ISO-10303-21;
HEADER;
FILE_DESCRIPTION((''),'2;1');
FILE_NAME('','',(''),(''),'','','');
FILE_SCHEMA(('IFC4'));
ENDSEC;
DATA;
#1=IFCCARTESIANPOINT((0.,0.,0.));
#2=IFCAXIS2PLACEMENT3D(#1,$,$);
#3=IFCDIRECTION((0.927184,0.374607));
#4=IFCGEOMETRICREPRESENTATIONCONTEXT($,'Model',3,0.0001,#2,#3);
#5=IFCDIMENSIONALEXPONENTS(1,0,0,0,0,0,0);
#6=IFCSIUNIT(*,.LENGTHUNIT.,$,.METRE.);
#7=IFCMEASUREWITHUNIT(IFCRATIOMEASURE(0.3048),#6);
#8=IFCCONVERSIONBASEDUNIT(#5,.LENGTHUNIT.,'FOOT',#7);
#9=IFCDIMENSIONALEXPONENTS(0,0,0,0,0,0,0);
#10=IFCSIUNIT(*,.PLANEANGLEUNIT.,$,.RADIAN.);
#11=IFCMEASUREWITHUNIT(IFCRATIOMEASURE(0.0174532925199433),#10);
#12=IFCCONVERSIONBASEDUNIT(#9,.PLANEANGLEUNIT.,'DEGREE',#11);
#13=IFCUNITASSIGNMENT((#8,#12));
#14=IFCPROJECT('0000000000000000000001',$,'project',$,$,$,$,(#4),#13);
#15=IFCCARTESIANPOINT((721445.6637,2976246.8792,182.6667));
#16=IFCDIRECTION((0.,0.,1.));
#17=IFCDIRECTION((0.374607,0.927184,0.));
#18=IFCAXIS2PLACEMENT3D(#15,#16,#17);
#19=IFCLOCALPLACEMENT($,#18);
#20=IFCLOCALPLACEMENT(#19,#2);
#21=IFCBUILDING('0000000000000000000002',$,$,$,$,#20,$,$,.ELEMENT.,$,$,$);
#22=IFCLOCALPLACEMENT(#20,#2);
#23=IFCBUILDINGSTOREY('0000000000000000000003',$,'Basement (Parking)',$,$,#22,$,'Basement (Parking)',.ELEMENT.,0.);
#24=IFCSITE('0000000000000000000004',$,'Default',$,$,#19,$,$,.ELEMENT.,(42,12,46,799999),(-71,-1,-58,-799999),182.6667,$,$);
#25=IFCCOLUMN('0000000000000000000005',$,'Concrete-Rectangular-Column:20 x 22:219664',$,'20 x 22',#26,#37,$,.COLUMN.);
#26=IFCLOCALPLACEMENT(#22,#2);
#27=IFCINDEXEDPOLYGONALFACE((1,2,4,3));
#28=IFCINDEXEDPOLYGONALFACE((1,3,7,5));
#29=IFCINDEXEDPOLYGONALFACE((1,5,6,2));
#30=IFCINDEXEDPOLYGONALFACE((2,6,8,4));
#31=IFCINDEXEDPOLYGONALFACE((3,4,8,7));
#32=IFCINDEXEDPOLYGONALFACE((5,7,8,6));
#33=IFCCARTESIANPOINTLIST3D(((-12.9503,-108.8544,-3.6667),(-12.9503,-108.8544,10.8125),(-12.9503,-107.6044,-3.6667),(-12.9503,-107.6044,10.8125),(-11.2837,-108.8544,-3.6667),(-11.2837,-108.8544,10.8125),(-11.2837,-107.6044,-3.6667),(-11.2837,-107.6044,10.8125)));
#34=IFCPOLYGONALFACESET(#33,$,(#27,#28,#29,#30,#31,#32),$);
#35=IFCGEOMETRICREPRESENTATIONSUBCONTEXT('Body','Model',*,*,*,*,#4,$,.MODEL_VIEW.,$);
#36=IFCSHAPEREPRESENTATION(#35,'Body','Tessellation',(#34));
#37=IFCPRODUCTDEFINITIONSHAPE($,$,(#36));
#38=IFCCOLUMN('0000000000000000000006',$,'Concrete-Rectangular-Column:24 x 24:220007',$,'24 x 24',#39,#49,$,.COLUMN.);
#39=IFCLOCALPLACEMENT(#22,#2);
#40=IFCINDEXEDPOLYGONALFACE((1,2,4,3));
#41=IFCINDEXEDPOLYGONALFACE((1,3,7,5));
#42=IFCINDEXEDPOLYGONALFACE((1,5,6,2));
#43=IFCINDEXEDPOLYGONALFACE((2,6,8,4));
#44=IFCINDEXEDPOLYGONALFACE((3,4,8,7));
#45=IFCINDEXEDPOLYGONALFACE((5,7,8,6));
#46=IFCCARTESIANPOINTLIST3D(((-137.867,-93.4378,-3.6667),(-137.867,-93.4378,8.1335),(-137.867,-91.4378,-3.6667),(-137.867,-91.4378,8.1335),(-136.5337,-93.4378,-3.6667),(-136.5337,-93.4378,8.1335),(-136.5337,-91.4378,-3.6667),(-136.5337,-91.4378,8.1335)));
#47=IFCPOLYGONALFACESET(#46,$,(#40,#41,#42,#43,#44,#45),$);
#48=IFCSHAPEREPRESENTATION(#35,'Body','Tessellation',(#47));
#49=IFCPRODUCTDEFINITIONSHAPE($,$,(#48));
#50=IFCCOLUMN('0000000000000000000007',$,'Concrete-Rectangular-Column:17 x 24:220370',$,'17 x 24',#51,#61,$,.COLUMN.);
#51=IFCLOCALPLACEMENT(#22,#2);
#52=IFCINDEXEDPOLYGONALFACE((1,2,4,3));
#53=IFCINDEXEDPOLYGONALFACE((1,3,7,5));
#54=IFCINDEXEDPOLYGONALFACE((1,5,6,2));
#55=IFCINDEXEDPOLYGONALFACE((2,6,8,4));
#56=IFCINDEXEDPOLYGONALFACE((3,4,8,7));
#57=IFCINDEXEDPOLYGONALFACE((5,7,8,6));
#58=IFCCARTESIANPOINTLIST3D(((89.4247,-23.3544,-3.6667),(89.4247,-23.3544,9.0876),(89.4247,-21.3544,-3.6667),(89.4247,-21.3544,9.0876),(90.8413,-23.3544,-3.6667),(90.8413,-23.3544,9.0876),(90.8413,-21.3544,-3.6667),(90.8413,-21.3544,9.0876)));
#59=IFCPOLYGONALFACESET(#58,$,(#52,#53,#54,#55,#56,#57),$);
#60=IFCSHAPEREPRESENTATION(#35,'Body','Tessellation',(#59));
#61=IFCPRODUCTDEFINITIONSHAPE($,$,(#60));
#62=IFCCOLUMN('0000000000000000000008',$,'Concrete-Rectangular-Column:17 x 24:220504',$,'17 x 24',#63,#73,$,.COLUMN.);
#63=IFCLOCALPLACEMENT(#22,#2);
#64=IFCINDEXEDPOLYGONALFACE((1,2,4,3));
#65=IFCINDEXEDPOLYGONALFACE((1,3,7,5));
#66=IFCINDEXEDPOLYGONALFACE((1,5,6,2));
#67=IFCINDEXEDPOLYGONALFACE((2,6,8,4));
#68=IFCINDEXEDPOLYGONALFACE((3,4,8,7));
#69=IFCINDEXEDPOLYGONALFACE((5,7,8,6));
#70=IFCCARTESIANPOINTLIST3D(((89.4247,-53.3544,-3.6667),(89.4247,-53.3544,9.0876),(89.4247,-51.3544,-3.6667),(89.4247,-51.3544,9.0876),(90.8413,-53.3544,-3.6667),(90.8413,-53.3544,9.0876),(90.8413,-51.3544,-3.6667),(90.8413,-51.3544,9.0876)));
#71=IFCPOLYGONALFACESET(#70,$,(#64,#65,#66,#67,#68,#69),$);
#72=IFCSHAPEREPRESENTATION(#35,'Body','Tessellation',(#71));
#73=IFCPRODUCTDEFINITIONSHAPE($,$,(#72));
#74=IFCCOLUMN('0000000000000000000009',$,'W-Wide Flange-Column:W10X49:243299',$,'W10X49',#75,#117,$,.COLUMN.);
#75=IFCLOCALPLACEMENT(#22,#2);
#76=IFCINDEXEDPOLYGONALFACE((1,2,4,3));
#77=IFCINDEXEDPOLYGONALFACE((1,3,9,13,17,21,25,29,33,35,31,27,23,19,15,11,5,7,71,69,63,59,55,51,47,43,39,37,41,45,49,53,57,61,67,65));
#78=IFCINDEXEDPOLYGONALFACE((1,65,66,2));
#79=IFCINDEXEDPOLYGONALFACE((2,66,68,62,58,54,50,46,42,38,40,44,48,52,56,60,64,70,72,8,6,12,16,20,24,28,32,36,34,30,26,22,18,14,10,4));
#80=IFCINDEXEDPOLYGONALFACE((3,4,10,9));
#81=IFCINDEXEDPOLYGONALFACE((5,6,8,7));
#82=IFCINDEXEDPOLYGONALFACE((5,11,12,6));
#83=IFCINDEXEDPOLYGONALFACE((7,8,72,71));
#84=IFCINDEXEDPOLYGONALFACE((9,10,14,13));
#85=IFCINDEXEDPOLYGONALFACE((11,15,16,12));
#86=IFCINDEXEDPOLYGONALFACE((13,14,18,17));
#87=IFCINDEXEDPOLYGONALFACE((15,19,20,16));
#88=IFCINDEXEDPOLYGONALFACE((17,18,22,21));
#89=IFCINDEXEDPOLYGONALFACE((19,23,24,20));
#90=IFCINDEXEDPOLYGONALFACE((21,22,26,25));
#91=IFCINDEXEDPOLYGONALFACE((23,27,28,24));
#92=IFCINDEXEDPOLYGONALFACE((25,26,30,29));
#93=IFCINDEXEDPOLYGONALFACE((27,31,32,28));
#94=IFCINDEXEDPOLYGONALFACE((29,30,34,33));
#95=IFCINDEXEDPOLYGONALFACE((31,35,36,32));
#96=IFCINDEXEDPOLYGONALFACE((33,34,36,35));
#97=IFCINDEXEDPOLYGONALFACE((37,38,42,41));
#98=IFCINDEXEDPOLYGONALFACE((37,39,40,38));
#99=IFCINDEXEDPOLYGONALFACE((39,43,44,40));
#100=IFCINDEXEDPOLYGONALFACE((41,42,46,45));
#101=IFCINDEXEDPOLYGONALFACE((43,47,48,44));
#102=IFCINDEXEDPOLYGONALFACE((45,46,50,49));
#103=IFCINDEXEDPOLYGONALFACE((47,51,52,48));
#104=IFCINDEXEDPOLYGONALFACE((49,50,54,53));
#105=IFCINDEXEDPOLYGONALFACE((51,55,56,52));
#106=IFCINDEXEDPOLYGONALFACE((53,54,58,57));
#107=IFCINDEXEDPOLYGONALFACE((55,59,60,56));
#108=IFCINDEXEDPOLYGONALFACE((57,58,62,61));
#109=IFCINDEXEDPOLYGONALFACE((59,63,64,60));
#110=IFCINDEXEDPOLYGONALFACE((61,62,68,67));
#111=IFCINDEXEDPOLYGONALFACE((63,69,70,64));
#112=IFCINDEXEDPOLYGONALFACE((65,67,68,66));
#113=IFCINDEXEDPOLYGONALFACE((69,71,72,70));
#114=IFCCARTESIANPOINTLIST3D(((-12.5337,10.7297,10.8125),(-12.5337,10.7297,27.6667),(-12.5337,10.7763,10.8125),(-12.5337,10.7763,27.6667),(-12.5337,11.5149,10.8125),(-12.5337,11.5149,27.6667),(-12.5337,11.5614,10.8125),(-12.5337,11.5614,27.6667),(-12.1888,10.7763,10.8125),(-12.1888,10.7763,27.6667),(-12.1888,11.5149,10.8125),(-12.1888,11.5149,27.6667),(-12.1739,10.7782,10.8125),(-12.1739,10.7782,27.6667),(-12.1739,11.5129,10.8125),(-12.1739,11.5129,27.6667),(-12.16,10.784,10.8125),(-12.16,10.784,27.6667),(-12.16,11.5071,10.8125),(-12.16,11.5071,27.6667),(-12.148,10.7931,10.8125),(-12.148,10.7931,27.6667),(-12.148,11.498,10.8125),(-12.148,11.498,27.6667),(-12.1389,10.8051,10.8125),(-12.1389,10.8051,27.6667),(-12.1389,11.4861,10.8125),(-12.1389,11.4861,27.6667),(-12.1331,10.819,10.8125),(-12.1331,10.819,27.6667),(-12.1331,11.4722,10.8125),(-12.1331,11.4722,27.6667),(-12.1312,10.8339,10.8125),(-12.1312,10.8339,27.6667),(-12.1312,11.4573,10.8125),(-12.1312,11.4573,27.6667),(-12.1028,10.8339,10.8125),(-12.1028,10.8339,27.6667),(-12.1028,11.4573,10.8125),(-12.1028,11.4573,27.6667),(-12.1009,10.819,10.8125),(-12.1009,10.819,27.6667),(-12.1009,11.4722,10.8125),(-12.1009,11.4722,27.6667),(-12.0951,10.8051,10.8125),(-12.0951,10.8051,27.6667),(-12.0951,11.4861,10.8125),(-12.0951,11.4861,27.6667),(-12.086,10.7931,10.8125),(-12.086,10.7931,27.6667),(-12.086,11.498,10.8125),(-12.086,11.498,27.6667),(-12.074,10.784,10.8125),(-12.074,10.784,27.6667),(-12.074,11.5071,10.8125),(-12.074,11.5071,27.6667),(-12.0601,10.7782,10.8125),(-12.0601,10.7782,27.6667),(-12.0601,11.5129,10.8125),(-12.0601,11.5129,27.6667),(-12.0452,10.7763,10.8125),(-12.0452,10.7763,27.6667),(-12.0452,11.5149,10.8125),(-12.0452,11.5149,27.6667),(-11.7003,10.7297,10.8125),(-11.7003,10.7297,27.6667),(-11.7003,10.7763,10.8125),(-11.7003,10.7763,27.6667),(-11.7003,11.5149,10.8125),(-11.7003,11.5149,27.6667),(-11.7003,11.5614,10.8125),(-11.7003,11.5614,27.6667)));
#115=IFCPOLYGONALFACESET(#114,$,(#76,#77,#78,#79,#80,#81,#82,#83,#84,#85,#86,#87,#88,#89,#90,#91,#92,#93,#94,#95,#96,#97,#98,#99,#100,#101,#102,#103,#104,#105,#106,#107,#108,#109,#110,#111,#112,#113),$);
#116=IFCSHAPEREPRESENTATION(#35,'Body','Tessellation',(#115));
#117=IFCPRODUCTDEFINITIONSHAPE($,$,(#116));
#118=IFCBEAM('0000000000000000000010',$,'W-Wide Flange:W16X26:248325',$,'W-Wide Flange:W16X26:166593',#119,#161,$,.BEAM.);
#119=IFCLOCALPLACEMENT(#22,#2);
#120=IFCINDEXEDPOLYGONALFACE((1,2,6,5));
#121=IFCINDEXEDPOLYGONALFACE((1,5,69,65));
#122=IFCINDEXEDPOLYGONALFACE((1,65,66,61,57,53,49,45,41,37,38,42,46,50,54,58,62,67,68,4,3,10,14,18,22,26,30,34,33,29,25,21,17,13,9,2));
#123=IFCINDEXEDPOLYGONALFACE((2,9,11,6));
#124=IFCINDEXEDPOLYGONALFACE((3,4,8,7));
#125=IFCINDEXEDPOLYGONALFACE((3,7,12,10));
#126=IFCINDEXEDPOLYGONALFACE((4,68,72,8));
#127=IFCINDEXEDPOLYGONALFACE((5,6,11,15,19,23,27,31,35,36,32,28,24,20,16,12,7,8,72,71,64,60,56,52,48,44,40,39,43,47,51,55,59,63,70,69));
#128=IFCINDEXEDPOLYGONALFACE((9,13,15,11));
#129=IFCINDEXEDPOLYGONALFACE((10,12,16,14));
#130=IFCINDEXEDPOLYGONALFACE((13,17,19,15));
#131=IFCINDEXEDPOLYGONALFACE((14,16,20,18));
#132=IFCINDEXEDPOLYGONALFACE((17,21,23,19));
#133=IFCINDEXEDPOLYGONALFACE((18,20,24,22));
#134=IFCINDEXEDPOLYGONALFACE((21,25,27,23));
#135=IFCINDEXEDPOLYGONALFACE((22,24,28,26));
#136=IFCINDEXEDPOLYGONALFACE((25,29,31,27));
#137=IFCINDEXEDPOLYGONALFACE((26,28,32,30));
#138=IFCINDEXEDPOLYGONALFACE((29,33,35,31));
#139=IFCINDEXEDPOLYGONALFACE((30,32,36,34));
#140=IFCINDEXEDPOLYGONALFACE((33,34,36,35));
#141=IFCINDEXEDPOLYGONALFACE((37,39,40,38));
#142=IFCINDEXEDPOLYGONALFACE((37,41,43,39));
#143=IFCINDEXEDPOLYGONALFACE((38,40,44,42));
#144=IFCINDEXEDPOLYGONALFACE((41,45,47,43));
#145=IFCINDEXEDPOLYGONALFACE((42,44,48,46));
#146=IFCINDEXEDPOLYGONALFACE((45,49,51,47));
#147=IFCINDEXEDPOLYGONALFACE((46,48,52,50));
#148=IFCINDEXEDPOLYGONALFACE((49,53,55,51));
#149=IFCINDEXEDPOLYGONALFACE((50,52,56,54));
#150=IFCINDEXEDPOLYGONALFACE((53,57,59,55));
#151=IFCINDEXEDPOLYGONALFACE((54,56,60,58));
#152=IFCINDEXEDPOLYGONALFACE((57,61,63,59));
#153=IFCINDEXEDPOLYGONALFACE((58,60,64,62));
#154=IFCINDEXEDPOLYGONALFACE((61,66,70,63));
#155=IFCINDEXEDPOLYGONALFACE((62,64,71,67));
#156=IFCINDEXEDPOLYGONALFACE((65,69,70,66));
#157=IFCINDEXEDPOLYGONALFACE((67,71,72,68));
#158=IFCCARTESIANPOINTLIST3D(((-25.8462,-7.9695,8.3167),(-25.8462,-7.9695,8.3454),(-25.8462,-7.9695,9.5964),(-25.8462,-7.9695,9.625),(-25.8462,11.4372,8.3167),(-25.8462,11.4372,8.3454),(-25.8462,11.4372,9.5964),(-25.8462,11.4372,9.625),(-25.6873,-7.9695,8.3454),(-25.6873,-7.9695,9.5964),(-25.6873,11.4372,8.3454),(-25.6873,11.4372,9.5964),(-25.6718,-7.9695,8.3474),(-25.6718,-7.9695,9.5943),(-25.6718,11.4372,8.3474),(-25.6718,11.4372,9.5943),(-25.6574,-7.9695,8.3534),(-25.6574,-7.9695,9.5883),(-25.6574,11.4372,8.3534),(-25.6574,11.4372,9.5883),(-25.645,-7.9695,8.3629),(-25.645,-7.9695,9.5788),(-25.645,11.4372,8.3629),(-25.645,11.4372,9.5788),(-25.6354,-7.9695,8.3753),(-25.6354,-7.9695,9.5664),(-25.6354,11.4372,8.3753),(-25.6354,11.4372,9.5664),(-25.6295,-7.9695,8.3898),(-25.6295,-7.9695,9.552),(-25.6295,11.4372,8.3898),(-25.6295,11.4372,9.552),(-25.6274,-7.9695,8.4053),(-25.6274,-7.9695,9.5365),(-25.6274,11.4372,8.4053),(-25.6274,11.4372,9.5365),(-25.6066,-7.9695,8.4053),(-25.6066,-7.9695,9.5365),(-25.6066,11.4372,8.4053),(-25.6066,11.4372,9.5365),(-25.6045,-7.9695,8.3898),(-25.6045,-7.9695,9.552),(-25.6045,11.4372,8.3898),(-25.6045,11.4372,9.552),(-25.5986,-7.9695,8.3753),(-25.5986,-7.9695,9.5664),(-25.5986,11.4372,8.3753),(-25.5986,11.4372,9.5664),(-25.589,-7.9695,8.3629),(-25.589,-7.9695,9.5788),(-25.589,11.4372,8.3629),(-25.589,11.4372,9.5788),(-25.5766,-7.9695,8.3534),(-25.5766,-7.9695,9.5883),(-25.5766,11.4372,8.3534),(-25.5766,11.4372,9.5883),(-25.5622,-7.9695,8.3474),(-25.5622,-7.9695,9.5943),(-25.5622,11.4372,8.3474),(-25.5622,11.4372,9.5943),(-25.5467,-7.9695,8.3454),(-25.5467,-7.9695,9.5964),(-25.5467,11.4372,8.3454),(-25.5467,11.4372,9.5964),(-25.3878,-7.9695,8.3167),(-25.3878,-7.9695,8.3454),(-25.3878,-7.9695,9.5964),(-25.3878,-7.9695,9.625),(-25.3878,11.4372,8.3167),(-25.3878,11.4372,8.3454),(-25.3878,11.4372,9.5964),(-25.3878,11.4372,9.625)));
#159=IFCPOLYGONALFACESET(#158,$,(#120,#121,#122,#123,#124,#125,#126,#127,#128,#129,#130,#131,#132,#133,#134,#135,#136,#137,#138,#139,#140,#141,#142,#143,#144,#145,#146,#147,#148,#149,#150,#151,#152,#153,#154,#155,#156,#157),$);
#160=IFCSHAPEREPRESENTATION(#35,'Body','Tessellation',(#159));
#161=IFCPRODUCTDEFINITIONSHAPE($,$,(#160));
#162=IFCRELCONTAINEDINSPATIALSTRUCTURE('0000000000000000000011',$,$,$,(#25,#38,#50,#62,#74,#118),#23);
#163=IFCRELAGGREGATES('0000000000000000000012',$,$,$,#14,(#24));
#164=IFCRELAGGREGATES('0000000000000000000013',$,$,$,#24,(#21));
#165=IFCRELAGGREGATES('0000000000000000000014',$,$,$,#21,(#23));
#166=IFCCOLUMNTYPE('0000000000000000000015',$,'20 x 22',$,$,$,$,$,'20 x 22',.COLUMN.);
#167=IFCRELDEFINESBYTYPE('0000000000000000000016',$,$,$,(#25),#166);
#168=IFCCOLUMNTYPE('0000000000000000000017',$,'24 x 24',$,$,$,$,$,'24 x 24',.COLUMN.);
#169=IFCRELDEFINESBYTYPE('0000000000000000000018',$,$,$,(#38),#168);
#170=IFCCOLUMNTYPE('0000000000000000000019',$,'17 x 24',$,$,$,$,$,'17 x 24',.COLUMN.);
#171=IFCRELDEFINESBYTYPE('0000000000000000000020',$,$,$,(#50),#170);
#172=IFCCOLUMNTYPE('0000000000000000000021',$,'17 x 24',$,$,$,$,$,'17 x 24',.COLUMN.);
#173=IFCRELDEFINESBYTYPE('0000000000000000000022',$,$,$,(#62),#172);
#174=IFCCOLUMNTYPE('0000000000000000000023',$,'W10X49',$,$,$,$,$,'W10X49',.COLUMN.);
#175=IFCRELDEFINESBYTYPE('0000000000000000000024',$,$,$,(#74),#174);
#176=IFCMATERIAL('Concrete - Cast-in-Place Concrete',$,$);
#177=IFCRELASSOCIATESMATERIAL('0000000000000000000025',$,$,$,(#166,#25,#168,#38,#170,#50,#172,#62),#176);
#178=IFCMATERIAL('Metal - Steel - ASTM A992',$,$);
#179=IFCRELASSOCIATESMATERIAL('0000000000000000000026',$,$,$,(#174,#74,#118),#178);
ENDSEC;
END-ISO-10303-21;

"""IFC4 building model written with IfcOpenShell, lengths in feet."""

from ifc_helpers import new_model, entity, si_unit, converted_unit, direction, frame, frame_2d, origin, origin_2d_with_axis, place, context, subcontext, project, spatial, rectangle, i_section, extrude, source, transform, mapped, material, type_object, type_shapes, element, save


model = new_model("IFC4")

# Units and contexts
model_context = context("Model", 3, precision=0.0001, world=origin(), true_north=direction((0.927184, 0.374607)))
body_context = subcontext(model_context, "Body", "Model", "MODEL_VIEW")
ifc_project = project(units=[converted_unit("LENGTHUNIT", "FOOT", entity("IfcRatioMeasure", 0.3048), si_unit("LENGTHUNIT", "METRE"), dimensions=[1, 0, 0, 0, 0, 0, 0]), converted_unit("PLANEANGLEUNIT", "DEGREE", entity("IfcRatioMeasure", 0.0174532925199433), si_unit("PLANEANGLEUNIT", "RADIAN"), dimensions=[0, 0, 0, 0, 0, 0, 0])], contexts=[model_context])

# Site, building, storey
site_placement = place(None, frame((721445.6637, 2976246.8792, 182.6667), z_axis=(0.0, 0.0, 1.0), x_axis=(0.374607, 0.927184, 0.0)))
site = spatial("IfcSite", under=ifc_project, at=site_placement, Name="Default", CompositionType="ELEMENT", RefLatitude=(42, 12, 46, 799999), RefLongitude=(-71, -1, -58, -799999), RefElevation=182.6667)
building_placement = place(site_placement, origin())
building = spatial("IfcBuilding", under=site, at=building_placement, CompositionType="ELEMENT")
storey_placement = place(building_placement, origin())
storey = spatial("IfcBuildingStorey", under=building, at=storey_placement, Name="Basement (Parking)", LongName="Basement (Parking)", CompositionType="ELEMENT", Elevation=0.0)

# Shared definitions
ifc_material_1 = material(Name="Concrete - Cast-in-Place Concrete")

# Columns
column_type_1 = type_object("IfcColumnType", Name="20 x 22", ElementType="20 x 22", PredefinedType="COLUMN", material=ifc_material_1)
shared_shape_1 = source(origin(), body_context, "Body", "SweptSolid", [
    extrude(rectangle(XDim=1.25, YDim=1.6667, at=frame_2d((0.0, 0.0), x_axis=(1.0, 0.0))), frame((-12.117, -108.2294, -3.6667), z_axis=(0.0, 0.0, 1.0), x_axis=(0.0, -1.0, 0.0)), (0.0, 0.0, 1.0), 14.4792),
])
type_shapes(column_type_1, [shared_shape_1])
column_1_placement = place(storey_placement, origin())
element("IfcColumn", 1, at=column_1_placement, inside=storey, type_object=column_type_1, material=ifc_material_1, Name="Concrete-Rectangular-Column:20 x 22:219664", ObjectType="20 x 22", PredefinedType="COLUMN", context=body_context, shape_type="MappedRepresentation", body=[
    mapped(shared_shape_1, transform((0.0, 0.0, 0.0), scale=1.0)),
])
column_type_2 = type_object("IfcColumnType", Name="24 x 24", ElementType="24 x 24", PredefinedType="COLUMN", material=ifc_material_1)
shared_shape_2 = source(origin(), body_context, "Body", "SweptSolid", [
    extrude(rectangle(XDim=2.0, YDim=1.3333, at=origin_2d_with_axis()), frame((-137.2003, -92.4378, -3.6667), z_axis=(0.0, 0.0, 1.0), x_axis=(0.0, -1.0, 0.0)), (0.0, 0.0, 1.0), 11.8001),
])
type_shapes(column_type_2, [shared_shape_2])
column_2_placement = place(storey_placement, origin())
element("IfcColumn", 2, at=column_2_placement, inside=storey, type_object=column_type_2, material=ifc_material_1, Name="Concrete-Rectangular-Column:24 x 24:220007", ObjectType="24 x 24", PredefinedType="COLUMN", context=body_context, shape_type="MappedRepresentation", body=[
    mapped(shared_shape_2, transform((0.0, 0.0, 0.0), scale=1.0)),
])
column_type_3 = type_object("IfcColumnType", Name="17 x 24", ElementType="17 x 24", PredefinedType="COLUMN", material=ifc_material_1)
shared_shape_3 = source(origin(), body_context, "Body", "SweptSolid", [
    extrude(rectangle(XDim=2.0, YDim=1.4167, at=origin_2d_with_axis()), frame((90.133, -22.3544, -3.6667), z_axis=(0.0, 0.0, 1.0), x_axis=(0.0, -1.0, 0.0)), (0.0, 0.0, 1.0), 12.7542),
])
type_shapes(column_type_3, [shared_shape_3])
column_3_placement = place(storey_placement, origin())
element("IfcColumn", 3, at=column_3_placement, inside=storey, type_object=column_type_3, material=ifc_material_1, Name="Concrete-Rectangular-Column:17 x 24:220370", ObjectType="17 x 24", PredefinedType="COLUMN", context=body_context, shape_type="MappedRepresentation", body=[
    mapped(shared_shape_3, transform((0.0, 0.0, 0.0), scale=1.0)),
])
column_type_4 = type_object("IfcColumnType", Name="17 x 24", ElementType="17 x 24", PredefinedType="COLUMN", material=ifc_material_1)
shared_shape_4 = source(origin(), body_context, "Body", "SweptSolid", [
    extrude(rectangle(XDim=2.0, YDim=1.4167, at=origin_2d_with_axis()), frame((90.133, -52.3544, -3.6667), z_axis=(0.0, 0.0, 1.0), x_axis=(0.0, -1.0, 0.0)), (0.0, 0.0, 1.0), 12.7542),
])
type_shapes(column_type_4, [shared_shape_4])
column_4_placement = place(storey_placement, origin())
element("IfcColumn", 4, at=column_4_placement, inside=storey, type_object=column_type_4, material=ifc_material_1, Name="Concrete-Rectangular-Column:17 x 24:220504", ObjectType="17 x 24", PredefinedType="COLUMN", context=body_context, shape_type="MappedRepresentation", body=[
    mapped(shared_shape_4, transform((0.0, 0.0, 0.0), scale=1.0)),
])
ifc_material_2 = material(Name="Metal - Steel - ASTM A992")
column_type_5 = type_object("IfcColumnType", Name="W10X49", ElementType="W10X49", PredefinedType="COLUMN", material=ifc_material_2)
shared_shape_5 = source(origin(), body_context, "Body", "SweptSolid", [
    extrude(i_section(OverallWidth=0.8333, OverallDepth=0.8317, WebThickness=0.0283, FlangeThickness=0.0465, FilletRadius=0.0576, at=frame_2d((0.0, 0.0), x_axis=(0.0, 1.0))), frame((0.0, 0.0, 10.8125), z_axis=(0.0, 0.0, 1.0), x_axis=(0.0, -1.0, 0.0)), (0.0, 0.0, 1.0), 16.8542),
])
type_shapes(column_type_5, [shared_shape_5])
column_5_placement = place(storey_placement, frame((-12.117, 11.1456, 0.0), z_axis=(0.0, 0.0, 1.0), x_axis=(-1.0, 0.0, 0.0)))
element("IfcColumn", 5, at=column_5_placement, inside=storey, type_object=column_type_5, material=ifc_material_2, Name="W-Wide Flange-Column:W10X49:243299", ObjectType="W10X49", PredefinedType="COLUMN", context=body_context, shape_type="MappedRepresentation", body=[
    mapped(shared_shape_5, transform((0.0, 0.0, 0.0), scale=1.0)),
])

# Beam
beam_1_placement = place(storey_placement, frame((-25.617, -8.3544, 9.625), z_axis=(0.0, 0.0, 1.0), x_axis=(0.0, 1.0, 0.0)))
element("IfcBeam", 6, at=beam_1_placement, inside=storey, material=ifc_material_2, Name="W-Wide Flange:W16X26:248325", ObjectType="W-Wide Flange:W16X26:166593", PredefinedType="BEAM", context=body_context, shape_type="SweptSolid", body=[
    extrude(i_section(OverallWidth=0.4583, OverallDepth=1.3083, WebThickness=0.0208, FlangeThickness=0.0286, FilletRadius=0.0599, at=frame_2d((0.0, 0.0), x_axis=(0.0, 1.0))), frame((0.3849, 0.0, -0.6541), z_axis=(1.0, 0.0, 0.0), x_axis=(0.0, 0.0, -1.0)), (0.0, 0.0, 1.0), 19.4067),
])

save(model, "model.ifc")
